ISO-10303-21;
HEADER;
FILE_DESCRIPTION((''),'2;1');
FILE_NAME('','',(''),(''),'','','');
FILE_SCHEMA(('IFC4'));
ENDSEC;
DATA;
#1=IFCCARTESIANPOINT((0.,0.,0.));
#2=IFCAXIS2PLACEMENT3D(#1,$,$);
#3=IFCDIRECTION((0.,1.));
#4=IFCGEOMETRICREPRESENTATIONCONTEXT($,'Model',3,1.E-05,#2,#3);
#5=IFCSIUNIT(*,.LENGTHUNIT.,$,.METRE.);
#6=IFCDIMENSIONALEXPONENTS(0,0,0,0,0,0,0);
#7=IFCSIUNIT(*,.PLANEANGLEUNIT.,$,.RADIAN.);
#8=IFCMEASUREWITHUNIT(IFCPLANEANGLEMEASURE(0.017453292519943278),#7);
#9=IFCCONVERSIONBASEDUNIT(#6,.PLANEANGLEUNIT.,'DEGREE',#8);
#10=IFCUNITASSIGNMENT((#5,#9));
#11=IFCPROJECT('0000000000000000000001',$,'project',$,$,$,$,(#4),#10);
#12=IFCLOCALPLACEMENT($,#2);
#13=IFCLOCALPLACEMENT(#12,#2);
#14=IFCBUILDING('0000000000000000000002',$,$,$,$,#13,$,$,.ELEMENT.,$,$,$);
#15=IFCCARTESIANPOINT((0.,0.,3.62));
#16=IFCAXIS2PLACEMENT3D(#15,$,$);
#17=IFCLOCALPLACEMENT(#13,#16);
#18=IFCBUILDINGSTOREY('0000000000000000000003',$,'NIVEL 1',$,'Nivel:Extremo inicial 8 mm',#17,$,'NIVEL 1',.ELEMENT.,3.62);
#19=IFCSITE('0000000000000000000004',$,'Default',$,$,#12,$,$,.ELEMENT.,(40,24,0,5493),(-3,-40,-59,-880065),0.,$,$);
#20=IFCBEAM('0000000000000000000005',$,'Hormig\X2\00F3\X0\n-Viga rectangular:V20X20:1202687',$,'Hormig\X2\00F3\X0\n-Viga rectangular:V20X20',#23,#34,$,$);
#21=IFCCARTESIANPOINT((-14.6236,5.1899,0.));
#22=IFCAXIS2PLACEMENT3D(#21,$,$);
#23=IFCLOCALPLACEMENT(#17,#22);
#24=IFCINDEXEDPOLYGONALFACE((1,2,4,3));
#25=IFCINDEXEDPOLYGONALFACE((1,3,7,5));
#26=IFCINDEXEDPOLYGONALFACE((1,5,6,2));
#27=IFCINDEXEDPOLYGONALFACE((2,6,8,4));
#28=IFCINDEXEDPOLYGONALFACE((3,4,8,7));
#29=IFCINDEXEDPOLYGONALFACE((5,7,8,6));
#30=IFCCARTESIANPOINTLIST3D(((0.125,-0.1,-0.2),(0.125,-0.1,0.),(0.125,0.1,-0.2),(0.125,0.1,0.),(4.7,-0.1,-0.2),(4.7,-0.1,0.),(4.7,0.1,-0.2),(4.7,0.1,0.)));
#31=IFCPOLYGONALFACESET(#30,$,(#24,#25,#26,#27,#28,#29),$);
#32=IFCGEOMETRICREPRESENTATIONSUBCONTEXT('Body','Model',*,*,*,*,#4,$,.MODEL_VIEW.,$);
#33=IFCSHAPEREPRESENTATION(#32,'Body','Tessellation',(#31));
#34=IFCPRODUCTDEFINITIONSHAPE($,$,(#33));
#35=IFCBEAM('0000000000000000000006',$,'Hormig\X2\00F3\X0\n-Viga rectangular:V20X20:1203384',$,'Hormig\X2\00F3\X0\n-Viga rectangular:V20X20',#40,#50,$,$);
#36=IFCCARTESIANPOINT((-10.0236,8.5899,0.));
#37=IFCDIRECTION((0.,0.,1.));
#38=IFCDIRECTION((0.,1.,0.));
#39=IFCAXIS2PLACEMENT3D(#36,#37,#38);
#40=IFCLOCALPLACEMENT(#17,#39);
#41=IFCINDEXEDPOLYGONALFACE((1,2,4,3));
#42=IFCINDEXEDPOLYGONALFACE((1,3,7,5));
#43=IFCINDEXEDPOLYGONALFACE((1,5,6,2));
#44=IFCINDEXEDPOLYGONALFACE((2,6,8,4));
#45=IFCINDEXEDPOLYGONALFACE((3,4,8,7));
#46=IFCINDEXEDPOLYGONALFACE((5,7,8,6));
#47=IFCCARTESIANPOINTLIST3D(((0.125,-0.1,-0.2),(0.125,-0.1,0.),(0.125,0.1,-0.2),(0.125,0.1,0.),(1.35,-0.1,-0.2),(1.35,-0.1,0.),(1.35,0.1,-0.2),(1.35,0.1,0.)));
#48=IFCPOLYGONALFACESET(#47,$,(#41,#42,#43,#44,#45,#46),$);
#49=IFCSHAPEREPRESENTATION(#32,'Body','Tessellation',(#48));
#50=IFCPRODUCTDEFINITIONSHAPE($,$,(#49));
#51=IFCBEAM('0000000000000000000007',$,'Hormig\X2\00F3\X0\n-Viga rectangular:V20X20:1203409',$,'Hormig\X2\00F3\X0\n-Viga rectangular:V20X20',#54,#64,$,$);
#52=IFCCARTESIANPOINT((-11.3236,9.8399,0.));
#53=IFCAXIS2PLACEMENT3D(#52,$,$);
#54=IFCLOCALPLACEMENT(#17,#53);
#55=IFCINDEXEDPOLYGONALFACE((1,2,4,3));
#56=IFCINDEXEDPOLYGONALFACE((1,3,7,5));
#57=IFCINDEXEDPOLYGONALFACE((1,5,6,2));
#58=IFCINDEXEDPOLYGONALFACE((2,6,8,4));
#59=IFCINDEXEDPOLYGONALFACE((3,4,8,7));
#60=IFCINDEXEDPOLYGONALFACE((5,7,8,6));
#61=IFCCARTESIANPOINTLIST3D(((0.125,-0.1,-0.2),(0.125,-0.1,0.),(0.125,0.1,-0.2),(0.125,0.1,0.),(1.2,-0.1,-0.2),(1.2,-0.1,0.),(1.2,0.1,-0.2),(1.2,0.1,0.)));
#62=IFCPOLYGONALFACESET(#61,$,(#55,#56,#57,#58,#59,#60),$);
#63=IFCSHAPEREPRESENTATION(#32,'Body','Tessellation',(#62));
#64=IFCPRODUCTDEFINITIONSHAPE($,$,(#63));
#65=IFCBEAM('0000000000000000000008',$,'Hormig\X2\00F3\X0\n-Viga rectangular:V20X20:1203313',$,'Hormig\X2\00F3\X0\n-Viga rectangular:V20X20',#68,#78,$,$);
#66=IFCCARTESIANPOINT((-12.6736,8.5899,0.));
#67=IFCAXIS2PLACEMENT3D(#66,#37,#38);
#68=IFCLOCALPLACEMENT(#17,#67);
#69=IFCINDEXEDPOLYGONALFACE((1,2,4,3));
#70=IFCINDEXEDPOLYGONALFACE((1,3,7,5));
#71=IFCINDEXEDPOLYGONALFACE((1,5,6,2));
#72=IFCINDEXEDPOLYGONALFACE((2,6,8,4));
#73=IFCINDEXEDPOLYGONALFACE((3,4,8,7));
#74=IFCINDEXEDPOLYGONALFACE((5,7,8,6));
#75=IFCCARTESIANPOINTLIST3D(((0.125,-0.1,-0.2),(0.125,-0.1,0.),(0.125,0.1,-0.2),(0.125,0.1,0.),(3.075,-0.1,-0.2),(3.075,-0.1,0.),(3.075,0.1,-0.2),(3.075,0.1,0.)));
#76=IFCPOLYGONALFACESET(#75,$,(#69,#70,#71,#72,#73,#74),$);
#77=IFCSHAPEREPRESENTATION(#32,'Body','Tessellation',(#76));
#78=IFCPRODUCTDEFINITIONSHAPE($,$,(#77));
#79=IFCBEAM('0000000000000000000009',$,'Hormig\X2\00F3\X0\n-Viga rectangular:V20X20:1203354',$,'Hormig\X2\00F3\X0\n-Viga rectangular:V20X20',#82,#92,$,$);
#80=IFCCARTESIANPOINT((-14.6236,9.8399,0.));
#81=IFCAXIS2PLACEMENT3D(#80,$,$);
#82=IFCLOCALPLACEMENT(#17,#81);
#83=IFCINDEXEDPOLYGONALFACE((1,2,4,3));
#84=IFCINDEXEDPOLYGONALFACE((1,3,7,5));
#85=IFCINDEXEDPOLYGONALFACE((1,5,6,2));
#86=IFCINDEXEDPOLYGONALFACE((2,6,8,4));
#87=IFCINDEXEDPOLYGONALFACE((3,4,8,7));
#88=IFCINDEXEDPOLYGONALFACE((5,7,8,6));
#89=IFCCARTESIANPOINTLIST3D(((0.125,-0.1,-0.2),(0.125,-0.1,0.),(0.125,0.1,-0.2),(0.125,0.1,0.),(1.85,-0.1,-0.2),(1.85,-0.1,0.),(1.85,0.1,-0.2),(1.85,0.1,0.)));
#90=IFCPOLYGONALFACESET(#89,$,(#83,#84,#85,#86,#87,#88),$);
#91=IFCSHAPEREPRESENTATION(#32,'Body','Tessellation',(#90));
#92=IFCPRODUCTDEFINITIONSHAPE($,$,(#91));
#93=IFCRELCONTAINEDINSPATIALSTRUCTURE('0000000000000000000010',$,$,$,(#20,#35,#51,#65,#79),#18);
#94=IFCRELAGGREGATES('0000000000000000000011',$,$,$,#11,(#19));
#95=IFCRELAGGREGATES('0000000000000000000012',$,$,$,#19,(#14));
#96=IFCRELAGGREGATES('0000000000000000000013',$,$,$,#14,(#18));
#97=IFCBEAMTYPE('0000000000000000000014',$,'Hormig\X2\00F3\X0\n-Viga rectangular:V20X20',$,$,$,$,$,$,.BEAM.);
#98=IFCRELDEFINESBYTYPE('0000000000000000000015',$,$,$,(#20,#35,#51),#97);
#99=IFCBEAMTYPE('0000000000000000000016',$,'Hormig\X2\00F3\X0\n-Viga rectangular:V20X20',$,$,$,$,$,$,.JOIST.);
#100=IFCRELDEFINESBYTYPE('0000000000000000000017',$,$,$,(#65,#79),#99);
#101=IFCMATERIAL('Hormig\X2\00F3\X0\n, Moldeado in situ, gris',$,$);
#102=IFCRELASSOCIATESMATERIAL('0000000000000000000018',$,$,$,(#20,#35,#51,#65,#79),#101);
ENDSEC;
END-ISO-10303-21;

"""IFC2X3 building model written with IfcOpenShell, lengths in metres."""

from ifc_helpers import new_model, entity, si_unit, converted_unit, direction, frame, frame_2d, origin, place, context, subcontext, project, spatial, rectangle, extrude, material, type_object, element, save


model = new_model("IFC2X3")

# Units and contexts
model_context = context("Model", 3, precision=1e-05, world=origin(), true_north=direction((0.0, 1.0)))
body_context = subcontext(model_context, "Body", "Model", "MODEL_VIEW")
ifc_project = project(units=[si_unit("LENGTHUNIT", "METRE"), converted_unit("PLANEANGLEUNIT", "DEGREE", entity("IfcPlaneAngleMeasure", 0.017453292519943278), si_unit("PLANEANGLEUNIT", "RADIAN"), dimensions=[0, 0, 0, 0, 0, 0, 0])], contexts=[model_context])

# Site, building, storey
site_placement = place(None, origin())
site = spatial("IfcSite", under=ifc_project, at=site_placement, Name="Default", CompositionType="ELEMENT", RefLatitude=(40, 24, 0, 5493), RefLongitude=(-3, -40, -59, -880065), RefElevation=0.0)
building_placement = place(site_placement, origin())
building = spatial("IfcBuilding", under=site, at=building_placement, CompositionType="ELEMENT")
storey_placement = place(building_placement, frame((0.0, 0.0, 3.62)))
storey = spatial("IfcBuildingStorey", under=building, at=storey_placement, Name="NIVEL 1", ObjectType="Nivel:Extremo inicial 8 mm", LongName="NIVEL 1", CompositionType="ELEMENT", Elevation=3.62)

# Shared definitions
ifc_material_1 = material(Name="Hormigón, Moldeado in situ, gris")

# Beams
beam_type_1 = type_object("IfcBeamType", Name="Hormigón-Viga rectangular:V20X20", PredefinedType="BEAM")
beam_1_placement = place(storey_placement, frame((-14.6236, 5.1899, 0.0)))
element("IfcBeam", 1, at=beam_1_placement, inside=storey, type_object=beam_type_1, material=ifc_material_1, Name="Hormigón-Viga rectangular:V20X20:1202687", ObjectType="Hormigón-Viga rectangular:V20X20", context=body_context, shape_type="SweptSolid", body=[
    extrude(rectangle(XDim=0.2, YDim=0.2, at=frame_2d((0.0, 0.0), x_axis=(1.0, 0.0))), frame((0.125, 0.0, -0.1), z_axis=(1.0, 0.0, 0.0), x_axis=(0.0, 0.0, -1.0)), (0.0, 0.0, 1.0), 4.575),
])
beam_2_placement = place(storey_placement, frame((-10.0236, 8.5899, 0.0), z_axis=(0.0, 0.0, 1.0), x_axis=(0.0, 1.0, 0.0)))
element("IfcBeam", 2, at=beam_2_placement, inside=storey, type_object=beam_type_1, material=ifc_material_1, Name="Hormigón-Viga rectangular:V20X20:1203384", ObjectType="Hormigón-Viga rectangular:V20X20", context=body_context, shape_type="SweptSolid", body=[
    extrude(rectangle(XDim=0.2, YDim=0.2, at=frame_2d((0.0, 0.0), x_axis=(1.0, 0.0))), frame((0.125, 0.0, -0.1), z_axis=(1.0, 0.0, 0.0), x_axis=(0.0, 0.0, -1.0)), (0.0, 0.0, 1.0), 1.225),
])
beam_3_placement = place(storey_placement, frame((-11.3236, 9.8399, 0.0)))
element("IfcBeam", 3, at=beam_3_placement, inside=storey, type_object=beam_type_1, material=ifc_material_1, Name="Hormigón-Viga rectangular:V20X20:1203409", ObjectType="Hormigón-Viga rectangular:V20X20", context=body_context, shape_type="SweptSolid", body=[
    extrude(rectangle(XDim=0.2, YDim=0.2, at=frame_2d((0.0, 0.0), x_axis=(1.0, 0.0))), frame((0.125, 0.0, -0.1), z_axis=(1.0, 0.0, 0.0), x_axis=(0.0, 0.0, -1.0)), (0.0, 0.0, 1.0), 1.075),
])
beam_type_2 = type_object("IfcBeamType", Name="Hormigón-Viga rectangular:V20X20", PredefinedType="JOIST")
beam_4_placement = place(storey_placement, frame((-12.6736, 8.5899, 0.0), z_axis=(0.0, 0.0, 1.0), x_axis=(0.0, 1.0, 0.0)))
element("IfcBeam", 4, at=beam_4_placement, inside=storey, type_object=beam_type_2, material=ifc_material_1, Name="Hormigón-Viga rectangular:V20X20:1203313", ObjectType="Hormigón-Viga rectangular:V20X20", context=body_context, shape_type="SweptSolid", body=[
    extrude(rectangle(XDim=0.2, YDim=0.2, at=frame_2d((0.0, 0.0), x_axis=(1.0, 0.0))), frame((0.125, 0.0, -0.1), z_axis=(1.0, 0.0, 0.0), x_axis=(0.0, 0.0, -1.0)), (0.0, 0.0, 1.0), 2.95),
])
beam_5_placement = place(storey_placement, frame((-14.6236, 9.8399, 0.0)))
element("IfcBeam", 5, at=beam_5_placement, inside=storey, type_object=beam_type_2, material=ifc_material_1, Name="Hormigón-Viga rectangular:V20X20:1203354", ObjectType="Hormigón-Viga rectangular:V20X20", context=body_context, shape_type="SweptSolid", body=[
    extrude(rectangle(XDim=0.2, YDim=0.2, at=frame_2d((0.0, 0.0), x_axis=(1.0, 0.0))), frame((0.125, 0.0, -0.1), z_axis=(1.0, 0.0, 0.0), x_axis=(0.0, 0.0, -1.0)), (0.0, 0.0, 1.0), 1.725),
])

save(model, "model.ifc")
